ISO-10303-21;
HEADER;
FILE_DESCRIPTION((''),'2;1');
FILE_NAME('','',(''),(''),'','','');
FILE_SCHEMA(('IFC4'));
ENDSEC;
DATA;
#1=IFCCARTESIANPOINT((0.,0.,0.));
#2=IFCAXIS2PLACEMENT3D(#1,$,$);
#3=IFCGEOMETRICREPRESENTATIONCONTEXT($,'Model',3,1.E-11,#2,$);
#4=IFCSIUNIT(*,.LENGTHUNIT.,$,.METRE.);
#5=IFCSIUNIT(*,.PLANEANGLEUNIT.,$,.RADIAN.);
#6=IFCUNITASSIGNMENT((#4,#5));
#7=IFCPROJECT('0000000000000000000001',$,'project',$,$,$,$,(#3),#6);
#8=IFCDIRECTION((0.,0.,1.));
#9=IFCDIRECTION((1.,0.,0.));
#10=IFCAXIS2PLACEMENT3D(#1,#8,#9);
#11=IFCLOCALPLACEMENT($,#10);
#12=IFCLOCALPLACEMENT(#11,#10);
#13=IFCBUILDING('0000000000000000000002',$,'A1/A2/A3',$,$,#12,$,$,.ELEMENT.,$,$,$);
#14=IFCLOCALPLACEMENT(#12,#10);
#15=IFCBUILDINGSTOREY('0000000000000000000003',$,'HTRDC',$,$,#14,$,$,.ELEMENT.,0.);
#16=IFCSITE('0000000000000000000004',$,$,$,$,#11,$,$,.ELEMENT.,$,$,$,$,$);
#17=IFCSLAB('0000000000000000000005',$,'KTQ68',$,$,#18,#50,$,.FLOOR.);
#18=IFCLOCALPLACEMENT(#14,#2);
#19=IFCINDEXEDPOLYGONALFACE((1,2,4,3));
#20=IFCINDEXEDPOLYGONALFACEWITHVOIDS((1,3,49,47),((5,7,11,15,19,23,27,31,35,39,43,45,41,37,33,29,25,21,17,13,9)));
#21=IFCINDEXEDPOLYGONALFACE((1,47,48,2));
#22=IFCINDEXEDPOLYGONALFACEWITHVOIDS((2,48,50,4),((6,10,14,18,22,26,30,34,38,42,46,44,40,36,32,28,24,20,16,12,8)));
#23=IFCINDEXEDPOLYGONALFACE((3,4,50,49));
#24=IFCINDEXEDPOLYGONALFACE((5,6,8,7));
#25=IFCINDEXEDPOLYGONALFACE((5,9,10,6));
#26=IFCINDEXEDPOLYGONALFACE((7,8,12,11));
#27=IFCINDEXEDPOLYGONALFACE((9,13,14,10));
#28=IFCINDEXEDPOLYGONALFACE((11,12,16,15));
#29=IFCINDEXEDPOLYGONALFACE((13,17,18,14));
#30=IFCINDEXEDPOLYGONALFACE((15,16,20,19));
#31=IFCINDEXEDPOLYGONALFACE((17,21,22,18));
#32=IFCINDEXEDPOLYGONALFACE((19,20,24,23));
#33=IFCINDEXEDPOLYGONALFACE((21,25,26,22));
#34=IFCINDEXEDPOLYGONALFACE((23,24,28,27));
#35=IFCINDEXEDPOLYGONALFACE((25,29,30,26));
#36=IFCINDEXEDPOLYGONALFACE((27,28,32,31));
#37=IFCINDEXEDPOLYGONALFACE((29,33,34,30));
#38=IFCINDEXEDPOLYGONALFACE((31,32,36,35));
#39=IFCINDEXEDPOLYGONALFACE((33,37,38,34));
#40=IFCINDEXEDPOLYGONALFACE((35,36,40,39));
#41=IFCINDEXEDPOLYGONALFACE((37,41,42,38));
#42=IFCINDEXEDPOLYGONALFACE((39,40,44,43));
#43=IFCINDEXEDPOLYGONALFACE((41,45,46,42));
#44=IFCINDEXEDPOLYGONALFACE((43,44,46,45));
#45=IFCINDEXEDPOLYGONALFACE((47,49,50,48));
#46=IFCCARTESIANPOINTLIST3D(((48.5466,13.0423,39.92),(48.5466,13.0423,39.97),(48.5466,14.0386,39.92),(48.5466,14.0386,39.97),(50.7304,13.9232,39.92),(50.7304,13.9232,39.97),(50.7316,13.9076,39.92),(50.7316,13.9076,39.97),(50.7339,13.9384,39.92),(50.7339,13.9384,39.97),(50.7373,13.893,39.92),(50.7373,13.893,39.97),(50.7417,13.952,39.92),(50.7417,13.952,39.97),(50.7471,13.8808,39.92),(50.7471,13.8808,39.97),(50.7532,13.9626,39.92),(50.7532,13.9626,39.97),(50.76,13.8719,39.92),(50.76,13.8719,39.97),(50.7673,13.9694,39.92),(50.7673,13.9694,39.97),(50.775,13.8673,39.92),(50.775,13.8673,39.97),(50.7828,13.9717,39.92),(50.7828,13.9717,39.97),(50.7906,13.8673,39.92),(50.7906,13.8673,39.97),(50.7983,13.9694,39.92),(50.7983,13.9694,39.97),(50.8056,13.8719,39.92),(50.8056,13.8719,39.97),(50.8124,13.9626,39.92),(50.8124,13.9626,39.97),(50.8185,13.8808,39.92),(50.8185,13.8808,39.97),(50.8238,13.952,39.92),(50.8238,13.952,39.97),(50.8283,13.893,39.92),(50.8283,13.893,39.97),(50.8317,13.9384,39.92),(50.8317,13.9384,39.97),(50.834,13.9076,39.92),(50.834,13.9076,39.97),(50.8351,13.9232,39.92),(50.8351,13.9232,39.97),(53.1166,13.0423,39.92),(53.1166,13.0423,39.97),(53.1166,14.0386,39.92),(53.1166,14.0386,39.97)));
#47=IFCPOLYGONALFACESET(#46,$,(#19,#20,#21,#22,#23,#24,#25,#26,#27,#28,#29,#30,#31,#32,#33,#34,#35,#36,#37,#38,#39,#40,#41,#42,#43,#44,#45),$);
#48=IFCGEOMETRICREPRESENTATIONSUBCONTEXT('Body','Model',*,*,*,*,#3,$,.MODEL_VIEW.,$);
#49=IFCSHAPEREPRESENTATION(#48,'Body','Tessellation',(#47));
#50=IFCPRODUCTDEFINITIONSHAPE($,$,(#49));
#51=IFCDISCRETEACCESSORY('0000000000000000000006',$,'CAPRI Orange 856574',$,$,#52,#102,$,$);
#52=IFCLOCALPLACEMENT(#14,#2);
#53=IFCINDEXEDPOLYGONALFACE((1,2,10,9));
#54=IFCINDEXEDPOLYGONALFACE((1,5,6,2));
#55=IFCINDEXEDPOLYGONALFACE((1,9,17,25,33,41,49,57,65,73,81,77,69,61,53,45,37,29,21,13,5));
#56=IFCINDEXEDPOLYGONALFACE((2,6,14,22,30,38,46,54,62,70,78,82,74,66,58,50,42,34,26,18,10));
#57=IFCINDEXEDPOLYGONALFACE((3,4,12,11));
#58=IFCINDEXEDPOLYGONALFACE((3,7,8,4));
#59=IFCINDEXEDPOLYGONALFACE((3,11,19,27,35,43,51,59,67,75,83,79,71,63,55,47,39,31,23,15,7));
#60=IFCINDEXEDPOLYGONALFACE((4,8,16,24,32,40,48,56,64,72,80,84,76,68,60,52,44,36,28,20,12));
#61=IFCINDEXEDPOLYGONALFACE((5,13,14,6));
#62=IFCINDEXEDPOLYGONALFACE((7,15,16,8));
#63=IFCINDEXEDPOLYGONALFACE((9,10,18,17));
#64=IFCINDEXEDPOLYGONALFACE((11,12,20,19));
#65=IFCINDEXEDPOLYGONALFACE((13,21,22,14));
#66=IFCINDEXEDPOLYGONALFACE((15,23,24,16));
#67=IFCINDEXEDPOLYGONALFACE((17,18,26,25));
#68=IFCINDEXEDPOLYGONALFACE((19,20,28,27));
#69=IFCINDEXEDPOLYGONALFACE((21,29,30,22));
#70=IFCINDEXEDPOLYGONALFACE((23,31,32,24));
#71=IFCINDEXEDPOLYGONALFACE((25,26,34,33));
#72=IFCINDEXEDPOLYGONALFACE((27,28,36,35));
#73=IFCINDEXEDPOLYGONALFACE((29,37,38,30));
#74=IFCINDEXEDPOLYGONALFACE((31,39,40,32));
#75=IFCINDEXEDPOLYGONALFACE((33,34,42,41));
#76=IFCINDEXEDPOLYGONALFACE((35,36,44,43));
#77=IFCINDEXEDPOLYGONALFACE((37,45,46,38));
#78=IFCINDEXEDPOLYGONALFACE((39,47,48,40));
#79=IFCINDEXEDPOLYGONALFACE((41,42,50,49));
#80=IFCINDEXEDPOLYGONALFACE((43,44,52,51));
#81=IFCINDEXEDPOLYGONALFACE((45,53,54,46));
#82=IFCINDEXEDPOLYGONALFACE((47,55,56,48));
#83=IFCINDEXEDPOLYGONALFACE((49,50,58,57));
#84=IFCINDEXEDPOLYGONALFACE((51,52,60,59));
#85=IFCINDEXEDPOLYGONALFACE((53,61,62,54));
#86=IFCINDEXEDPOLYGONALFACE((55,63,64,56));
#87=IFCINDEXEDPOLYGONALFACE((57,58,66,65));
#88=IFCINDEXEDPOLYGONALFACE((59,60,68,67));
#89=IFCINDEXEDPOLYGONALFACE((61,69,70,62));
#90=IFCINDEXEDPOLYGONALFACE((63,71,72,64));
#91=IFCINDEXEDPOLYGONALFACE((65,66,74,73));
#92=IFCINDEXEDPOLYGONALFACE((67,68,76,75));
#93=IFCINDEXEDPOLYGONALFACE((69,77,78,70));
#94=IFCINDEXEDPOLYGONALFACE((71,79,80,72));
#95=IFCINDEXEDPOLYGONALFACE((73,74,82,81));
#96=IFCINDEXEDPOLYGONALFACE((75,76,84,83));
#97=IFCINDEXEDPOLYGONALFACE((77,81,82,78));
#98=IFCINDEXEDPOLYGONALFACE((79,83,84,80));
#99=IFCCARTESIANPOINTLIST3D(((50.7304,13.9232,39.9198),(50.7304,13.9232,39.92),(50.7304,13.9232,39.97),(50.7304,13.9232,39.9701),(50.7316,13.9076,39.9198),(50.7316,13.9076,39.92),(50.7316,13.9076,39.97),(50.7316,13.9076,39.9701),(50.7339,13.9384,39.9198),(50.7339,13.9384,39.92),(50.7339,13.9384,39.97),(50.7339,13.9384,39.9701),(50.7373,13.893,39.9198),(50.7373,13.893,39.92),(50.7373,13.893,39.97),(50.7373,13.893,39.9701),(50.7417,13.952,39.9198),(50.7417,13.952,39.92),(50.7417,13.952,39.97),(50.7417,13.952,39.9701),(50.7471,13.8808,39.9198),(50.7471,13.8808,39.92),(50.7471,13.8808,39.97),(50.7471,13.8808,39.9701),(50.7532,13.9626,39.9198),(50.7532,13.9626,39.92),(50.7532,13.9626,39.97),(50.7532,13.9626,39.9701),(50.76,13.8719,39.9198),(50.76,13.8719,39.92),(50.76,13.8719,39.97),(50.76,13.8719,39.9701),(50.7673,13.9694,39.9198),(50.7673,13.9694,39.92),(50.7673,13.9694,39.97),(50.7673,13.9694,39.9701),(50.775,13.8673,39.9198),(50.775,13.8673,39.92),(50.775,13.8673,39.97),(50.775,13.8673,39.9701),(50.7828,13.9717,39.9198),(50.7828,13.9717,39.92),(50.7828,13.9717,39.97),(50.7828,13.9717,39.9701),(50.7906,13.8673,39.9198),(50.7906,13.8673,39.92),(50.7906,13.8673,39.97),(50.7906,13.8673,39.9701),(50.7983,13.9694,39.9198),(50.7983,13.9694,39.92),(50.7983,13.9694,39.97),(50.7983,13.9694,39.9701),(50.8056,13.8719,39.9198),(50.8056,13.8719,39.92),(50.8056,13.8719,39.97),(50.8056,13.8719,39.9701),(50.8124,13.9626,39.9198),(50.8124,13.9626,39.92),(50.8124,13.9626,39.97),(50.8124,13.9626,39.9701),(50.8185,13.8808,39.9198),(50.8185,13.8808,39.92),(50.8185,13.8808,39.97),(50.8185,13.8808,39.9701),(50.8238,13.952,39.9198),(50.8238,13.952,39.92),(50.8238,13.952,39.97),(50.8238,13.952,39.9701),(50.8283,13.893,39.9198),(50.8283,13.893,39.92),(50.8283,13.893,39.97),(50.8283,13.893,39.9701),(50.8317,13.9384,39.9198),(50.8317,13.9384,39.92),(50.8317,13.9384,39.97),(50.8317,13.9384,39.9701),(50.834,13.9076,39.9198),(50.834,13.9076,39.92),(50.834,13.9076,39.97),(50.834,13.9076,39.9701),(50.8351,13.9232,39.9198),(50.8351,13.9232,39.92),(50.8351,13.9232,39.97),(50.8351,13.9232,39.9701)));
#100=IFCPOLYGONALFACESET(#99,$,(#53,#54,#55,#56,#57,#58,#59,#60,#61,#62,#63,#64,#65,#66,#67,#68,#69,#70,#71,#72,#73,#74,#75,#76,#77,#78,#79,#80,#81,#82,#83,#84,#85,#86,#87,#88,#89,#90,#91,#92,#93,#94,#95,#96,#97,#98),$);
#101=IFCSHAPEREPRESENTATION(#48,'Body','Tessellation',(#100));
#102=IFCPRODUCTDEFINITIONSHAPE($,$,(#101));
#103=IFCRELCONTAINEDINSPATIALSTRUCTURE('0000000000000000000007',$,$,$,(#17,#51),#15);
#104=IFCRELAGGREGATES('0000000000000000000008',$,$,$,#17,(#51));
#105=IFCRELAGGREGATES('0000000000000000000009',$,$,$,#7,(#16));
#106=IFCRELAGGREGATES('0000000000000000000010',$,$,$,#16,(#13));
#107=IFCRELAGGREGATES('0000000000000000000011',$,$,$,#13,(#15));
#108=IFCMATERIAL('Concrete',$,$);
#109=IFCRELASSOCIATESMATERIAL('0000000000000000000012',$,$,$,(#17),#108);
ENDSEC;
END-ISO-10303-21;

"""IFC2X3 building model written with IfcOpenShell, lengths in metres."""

from ifc_helpers import new_model, si_unit, frame, frame_2d, origin, origin_with_axes, origin_2d_with_axis, place, context, subcontext, project, spatial, polyline, circle, outline, extrude, material, element, aggregate, save


model = new_model("IFC2X3")

# Units and contexts
model_context = context("Model", 3, precision=1e-11, world=origin())
body_context = subcontext(model_context, "Body", "Model", "MODEL_VIEW")
ifc_project = project(units=[si_unit("LENGTHUNIT", "METRE"), si_unit("PLANEANGLEUNIT", "RADIAN")], contexts=[model_context])

# Site, building, storey
site_placement = place(None, origin_with_axes())
site = spatial("IfcSite", under=ifc_project, at=site_placement, CompositionType="ELEMENT")
building_placement = place(site_placement, origin_with_axes())
building = spatial("IfcBuilding", under=site, at=building_placement, Name="A1/A2/A3", CompositionType="ELEMENT")
storey_placement = place(building_placement, origin_with_axes())
storey = spatial("IfcBuildingStorey", under=building, at=storey_placement, Name="HTRDC", CompositionType="ELEMENT", Elevation=0.0)

# Shared definitions
ifc_material = material(Name="Concrete")

# Slab, opening
slab_1_placement = place(storey_placement, frame((48.5466, 13.0423, 39.92), z_axis=(0.0, 0.0, 1.0), x_axis=(1.0, 0.0, 0.0)))
slab_1 = element("IfcSlab", 1, at=slab_1_placement, inside=storey, material=ifc_material, Name="KTQ68", PredefinedType="FLOOR", context=body_context, shape_type="SweptSolid", body=[
    extrude(outline(polyline([(0.0, 0.0), (0.0, -4.57), (0.9963, -4.57), (0.9963, 0.0), (0.0, 0.0)])), frame((0.0, 0.0, 0.0), z_axis=(0.0, 0.0, 1.0), x_axis=(0.0, 1.0, 0.0)), (0.0, 0.0, 1.0), 0.05),
])
opening_1_placement = place(slab_1_placement, frame((2.2362, 0.8769, 0.0), z_axis=(0.0, 0.0, 1.0), x_axis=(1.0, 0.0, 0.0)))
element("IfcOpeningElement", 2, at=opening_1_placement, cuts=slab_1, ObjectType="Opening", context=body_context, shape_type="SweptSolid", body=[
    extrude(circle(Radius=0.0525, at=origin_2d_with_axis()), frame((0.0, 0.0, 0.0), z_axis=(0.0, 0.0, 1.0), x_axis=(0.0, 1.0, 0.0)), (0.0, 0.0, 1.0), 0.05),
])

# Discrete accessory
discrete_accessory_1_placement = place(storey_placement, frame((48.5466, 13.0423, 39.9198), z_axis=(0.0, 0.0, 1.0), x_axis=(1.0, 0.0, 0.0)))
discrete_accessory_1 = element("IfcDiscreteAccessory", 3, at=discrete_accessory_1_placement, inside=storey, Name="CAPRI Orange 856574", context=body_context, shape_type="SweptSolid", body=[
    extrude(circle(Radius=0.0525, at=frame_2d((0.8769, -2.2362), x_axis=(1.0, 0.0))), frame((0.0, 0.0, 0.0), z_axis=(0.0, 0.0, 1.0), x_axis=(0.0, 1.0, 0.0)), (0.0, 0.0, 1.0), 0.0503),
])
aggregate(slab_1, [discrete_accessory_1])

save(model, "model.ifc")
